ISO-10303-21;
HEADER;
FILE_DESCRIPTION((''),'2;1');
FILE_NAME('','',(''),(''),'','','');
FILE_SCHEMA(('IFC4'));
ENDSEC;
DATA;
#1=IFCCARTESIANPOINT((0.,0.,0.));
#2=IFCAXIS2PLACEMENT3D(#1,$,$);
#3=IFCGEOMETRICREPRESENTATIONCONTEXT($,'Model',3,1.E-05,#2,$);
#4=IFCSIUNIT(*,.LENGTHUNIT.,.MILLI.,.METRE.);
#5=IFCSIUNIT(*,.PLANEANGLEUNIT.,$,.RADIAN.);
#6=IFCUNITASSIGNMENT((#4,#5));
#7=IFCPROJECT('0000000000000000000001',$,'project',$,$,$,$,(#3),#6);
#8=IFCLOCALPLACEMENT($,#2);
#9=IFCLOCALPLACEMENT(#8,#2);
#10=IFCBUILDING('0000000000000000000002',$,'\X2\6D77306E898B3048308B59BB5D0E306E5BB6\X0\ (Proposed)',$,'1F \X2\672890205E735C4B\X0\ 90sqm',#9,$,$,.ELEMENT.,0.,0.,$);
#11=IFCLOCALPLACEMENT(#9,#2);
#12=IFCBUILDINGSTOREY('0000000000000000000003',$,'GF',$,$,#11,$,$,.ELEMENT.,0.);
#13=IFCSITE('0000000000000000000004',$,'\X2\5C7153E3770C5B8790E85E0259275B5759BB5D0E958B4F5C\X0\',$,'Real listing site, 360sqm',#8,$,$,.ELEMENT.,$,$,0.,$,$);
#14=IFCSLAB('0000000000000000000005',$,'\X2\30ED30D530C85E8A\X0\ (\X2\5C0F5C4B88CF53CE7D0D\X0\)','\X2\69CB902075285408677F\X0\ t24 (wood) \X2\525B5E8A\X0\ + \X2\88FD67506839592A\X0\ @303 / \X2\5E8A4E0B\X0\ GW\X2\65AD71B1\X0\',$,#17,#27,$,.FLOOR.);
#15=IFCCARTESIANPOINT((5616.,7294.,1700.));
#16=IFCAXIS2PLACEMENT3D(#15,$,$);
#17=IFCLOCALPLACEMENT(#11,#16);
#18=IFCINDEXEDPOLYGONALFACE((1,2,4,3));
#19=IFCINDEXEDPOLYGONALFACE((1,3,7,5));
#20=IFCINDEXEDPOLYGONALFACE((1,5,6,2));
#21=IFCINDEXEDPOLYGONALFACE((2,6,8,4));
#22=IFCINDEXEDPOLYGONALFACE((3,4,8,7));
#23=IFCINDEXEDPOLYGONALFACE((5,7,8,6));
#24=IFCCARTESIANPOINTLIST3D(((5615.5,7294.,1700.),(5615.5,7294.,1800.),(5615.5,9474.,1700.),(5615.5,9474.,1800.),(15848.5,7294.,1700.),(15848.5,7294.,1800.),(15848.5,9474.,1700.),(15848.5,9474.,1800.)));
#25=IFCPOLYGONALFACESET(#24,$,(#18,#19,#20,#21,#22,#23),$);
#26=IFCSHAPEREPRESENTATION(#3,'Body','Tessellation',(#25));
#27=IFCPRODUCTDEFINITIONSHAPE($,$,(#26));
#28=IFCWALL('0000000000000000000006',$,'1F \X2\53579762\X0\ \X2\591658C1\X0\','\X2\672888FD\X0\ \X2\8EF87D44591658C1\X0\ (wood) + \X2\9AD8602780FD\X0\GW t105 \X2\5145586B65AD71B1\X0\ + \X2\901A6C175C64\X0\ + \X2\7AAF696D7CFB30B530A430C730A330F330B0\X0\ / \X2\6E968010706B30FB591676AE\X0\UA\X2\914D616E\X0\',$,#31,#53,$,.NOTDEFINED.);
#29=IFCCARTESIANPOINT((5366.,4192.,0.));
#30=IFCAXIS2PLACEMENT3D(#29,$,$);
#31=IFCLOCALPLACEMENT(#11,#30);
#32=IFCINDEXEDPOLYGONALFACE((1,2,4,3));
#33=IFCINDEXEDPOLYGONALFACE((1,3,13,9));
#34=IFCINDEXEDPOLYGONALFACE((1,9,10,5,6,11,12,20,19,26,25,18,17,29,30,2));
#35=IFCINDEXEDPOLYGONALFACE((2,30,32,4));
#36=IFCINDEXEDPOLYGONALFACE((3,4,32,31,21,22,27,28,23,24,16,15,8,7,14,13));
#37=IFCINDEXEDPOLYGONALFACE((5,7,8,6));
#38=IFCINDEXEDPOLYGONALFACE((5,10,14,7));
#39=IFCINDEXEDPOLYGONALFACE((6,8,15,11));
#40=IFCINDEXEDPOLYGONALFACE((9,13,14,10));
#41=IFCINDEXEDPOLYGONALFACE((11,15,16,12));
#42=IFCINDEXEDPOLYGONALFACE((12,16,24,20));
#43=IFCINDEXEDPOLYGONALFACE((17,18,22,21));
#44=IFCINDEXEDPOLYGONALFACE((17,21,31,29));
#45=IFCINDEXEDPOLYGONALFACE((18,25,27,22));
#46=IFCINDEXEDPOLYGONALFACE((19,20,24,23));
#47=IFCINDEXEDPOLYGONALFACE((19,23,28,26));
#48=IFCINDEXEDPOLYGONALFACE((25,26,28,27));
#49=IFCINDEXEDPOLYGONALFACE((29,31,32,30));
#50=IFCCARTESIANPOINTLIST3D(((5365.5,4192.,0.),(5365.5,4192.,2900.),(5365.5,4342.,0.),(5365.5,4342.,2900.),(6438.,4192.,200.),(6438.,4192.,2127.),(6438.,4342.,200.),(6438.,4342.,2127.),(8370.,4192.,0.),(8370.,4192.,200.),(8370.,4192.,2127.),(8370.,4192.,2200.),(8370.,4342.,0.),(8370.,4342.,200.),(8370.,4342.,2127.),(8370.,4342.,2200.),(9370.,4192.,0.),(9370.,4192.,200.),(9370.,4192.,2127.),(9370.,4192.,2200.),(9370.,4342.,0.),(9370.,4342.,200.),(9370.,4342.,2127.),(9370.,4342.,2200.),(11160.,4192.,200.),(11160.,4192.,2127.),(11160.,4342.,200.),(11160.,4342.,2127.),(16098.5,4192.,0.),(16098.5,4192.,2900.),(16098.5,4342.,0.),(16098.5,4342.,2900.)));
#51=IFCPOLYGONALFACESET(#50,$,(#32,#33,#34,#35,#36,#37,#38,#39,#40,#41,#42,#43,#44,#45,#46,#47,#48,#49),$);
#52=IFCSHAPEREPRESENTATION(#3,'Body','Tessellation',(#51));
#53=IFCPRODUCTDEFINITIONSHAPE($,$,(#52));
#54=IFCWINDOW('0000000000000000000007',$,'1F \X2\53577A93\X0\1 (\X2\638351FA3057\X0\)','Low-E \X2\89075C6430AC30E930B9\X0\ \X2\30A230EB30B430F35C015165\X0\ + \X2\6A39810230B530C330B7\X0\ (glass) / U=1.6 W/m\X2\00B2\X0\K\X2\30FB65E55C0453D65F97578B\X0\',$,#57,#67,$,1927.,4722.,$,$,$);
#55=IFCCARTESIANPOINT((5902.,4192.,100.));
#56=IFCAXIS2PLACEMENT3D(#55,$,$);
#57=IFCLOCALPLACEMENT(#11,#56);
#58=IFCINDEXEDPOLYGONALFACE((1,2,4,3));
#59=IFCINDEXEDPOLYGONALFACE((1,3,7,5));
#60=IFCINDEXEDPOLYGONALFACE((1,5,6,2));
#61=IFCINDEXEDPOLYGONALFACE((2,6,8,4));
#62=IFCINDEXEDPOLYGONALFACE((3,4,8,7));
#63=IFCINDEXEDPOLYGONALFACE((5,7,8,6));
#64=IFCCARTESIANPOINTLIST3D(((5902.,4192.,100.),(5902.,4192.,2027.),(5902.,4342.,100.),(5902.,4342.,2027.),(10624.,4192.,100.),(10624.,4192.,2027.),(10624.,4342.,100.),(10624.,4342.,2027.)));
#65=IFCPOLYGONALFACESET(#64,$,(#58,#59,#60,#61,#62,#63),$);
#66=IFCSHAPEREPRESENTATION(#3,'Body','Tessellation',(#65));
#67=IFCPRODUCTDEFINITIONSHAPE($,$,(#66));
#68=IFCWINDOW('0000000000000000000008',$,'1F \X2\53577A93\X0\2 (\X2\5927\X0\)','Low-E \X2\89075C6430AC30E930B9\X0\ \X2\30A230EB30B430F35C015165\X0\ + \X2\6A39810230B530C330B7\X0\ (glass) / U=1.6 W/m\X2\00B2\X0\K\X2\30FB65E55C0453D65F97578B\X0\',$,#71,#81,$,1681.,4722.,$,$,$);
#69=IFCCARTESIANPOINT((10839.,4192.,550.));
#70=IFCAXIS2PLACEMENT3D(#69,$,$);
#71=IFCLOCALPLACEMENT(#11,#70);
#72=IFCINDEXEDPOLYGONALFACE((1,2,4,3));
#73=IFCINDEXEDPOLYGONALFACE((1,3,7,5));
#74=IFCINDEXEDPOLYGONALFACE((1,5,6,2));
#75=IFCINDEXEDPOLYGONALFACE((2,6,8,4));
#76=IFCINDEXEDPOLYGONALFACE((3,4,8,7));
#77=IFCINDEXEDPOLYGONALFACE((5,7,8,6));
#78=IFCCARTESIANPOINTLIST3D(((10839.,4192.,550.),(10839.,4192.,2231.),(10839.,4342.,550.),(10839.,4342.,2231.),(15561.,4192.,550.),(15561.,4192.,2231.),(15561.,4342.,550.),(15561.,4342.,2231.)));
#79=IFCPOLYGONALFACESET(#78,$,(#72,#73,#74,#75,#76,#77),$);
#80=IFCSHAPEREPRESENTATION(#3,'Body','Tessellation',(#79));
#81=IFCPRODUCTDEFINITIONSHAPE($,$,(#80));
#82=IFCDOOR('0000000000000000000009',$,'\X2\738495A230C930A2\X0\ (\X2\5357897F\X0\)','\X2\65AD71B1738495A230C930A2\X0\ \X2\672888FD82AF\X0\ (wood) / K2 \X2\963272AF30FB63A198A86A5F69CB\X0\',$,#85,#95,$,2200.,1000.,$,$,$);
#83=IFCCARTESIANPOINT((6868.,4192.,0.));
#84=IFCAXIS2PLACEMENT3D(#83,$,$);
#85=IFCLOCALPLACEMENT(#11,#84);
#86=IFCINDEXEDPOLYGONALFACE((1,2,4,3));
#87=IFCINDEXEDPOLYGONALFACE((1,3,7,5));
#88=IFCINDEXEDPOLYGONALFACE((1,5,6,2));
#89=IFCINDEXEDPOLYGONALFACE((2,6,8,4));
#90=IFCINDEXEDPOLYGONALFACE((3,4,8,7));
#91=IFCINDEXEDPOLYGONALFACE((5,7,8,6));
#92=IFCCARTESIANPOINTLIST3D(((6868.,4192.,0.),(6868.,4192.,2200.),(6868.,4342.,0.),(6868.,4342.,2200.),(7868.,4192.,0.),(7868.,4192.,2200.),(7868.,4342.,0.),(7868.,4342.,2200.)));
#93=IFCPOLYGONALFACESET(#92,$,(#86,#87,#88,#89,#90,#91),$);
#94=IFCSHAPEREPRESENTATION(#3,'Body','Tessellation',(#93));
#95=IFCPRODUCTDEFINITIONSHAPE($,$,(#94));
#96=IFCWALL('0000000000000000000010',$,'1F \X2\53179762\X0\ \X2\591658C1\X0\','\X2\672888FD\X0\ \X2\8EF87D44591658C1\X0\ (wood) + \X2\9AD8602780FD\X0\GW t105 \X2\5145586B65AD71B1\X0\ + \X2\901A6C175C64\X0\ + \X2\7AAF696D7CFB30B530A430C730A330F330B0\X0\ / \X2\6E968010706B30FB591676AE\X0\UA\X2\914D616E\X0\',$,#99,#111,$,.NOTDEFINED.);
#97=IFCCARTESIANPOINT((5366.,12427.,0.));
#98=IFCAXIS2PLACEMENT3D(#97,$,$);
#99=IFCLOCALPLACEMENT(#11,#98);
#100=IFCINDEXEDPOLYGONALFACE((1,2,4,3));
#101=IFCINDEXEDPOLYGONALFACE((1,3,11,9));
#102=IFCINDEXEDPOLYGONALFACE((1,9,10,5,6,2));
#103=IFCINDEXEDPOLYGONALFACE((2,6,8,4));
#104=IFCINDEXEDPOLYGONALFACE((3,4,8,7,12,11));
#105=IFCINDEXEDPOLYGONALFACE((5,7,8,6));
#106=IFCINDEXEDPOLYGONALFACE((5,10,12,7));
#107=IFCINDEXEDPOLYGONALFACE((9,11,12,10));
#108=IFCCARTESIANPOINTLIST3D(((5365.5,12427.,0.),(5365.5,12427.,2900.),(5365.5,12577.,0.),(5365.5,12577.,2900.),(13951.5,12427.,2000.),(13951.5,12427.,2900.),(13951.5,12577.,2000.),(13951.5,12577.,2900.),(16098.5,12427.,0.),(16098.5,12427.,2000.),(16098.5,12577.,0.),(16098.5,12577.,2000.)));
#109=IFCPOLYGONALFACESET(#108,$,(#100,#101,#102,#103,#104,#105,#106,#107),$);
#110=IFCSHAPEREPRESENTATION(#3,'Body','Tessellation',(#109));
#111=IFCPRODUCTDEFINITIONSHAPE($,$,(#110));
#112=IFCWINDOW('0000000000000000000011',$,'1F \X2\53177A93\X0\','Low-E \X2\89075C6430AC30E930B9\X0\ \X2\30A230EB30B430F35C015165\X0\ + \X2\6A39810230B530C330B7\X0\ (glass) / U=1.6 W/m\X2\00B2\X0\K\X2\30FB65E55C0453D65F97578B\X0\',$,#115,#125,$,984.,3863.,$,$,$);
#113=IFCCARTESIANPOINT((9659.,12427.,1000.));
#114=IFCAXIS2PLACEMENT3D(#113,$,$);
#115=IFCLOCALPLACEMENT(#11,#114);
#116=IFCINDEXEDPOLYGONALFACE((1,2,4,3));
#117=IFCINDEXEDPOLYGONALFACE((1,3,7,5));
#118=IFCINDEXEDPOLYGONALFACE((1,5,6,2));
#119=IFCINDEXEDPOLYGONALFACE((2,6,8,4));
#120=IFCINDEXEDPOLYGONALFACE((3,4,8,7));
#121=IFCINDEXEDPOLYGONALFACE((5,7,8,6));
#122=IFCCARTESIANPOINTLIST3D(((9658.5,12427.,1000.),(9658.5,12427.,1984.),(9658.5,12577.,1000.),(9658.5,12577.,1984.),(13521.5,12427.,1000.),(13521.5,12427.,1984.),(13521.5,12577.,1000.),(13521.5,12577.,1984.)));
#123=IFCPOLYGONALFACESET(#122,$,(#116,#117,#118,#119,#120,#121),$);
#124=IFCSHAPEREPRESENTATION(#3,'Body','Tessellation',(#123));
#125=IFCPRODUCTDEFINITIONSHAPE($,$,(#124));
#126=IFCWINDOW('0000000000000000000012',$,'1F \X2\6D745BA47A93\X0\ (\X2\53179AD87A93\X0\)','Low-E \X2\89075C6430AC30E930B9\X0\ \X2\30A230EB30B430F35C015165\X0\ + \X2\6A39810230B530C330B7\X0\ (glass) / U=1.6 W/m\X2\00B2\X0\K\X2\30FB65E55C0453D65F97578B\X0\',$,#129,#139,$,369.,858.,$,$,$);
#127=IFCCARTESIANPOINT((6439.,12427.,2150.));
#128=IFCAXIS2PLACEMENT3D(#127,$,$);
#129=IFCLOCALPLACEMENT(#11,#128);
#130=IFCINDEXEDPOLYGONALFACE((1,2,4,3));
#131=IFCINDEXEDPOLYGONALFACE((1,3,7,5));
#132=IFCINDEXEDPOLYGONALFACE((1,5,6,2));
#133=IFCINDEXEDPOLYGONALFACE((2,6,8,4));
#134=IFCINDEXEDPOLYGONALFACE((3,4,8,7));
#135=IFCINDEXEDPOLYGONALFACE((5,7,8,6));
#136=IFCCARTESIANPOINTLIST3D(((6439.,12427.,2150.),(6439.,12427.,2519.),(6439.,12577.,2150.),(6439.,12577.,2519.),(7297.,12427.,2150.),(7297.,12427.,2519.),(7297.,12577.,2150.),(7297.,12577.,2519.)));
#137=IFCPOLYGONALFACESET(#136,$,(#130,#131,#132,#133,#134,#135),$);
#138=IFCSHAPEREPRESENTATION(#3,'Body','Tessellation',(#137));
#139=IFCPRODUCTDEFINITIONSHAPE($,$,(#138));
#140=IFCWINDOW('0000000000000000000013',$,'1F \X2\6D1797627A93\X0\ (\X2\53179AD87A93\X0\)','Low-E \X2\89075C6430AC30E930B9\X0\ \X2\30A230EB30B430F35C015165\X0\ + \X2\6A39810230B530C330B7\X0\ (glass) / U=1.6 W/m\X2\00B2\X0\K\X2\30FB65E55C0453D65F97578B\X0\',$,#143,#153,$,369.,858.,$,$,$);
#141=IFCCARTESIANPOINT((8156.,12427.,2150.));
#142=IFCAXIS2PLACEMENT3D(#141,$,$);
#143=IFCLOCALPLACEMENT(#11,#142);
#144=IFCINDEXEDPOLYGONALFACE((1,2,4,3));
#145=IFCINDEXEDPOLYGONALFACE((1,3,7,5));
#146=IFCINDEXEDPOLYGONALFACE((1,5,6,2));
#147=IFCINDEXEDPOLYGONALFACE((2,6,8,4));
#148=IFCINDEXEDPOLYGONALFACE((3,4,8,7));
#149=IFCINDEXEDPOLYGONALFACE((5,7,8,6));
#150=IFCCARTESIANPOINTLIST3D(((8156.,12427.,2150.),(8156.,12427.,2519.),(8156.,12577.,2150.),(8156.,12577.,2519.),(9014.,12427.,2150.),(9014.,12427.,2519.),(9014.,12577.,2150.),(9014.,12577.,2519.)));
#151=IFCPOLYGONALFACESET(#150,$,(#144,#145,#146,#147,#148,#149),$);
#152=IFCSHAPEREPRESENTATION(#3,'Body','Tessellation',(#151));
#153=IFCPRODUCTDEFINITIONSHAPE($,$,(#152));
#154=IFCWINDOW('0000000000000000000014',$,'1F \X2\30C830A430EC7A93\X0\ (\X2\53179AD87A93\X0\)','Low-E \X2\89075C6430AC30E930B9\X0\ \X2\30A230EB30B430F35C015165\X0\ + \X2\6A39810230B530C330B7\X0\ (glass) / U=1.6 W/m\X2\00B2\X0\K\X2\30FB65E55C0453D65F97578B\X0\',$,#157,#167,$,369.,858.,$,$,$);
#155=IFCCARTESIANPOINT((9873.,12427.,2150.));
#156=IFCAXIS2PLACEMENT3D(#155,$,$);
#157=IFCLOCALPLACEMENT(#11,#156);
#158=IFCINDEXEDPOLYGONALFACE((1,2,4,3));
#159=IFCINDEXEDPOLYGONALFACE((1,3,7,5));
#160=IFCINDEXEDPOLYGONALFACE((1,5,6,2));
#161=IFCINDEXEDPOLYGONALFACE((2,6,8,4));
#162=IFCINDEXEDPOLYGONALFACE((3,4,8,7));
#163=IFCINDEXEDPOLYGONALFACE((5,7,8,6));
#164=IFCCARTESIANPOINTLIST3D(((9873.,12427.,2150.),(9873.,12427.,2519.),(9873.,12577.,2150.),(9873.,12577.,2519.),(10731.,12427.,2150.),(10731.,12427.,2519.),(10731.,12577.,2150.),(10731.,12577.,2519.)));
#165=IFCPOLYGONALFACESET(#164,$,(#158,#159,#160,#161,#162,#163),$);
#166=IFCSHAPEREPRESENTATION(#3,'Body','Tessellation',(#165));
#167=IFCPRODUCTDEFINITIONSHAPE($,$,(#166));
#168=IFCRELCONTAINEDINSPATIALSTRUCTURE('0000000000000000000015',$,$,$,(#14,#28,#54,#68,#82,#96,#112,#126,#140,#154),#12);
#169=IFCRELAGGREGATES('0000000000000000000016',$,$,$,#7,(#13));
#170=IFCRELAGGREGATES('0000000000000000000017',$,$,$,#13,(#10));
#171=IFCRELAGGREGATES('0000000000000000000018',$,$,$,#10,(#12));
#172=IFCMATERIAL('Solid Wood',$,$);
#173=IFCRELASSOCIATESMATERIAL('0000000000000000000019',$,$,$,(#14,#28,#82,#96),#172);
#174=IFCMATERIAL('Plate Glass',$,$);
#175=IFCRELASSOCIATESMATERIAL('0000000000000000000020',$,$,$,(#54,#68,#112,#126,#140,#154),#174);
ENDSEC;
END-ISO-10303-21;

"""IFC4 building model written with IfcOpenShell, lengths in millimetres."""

from ifc_helpers import new_model, si_unit, frame, frame_2d, origin, place, context, project, spatial, rectangle, extrude, material, element, fill, save


model = new_model("IFC4")

# Units and contexts
model_context = context("Model", 3, precision=1e-05, world=origin())
ifc_project = project(units=[si_unit("LENGTHUNIT", "METRE", prefix="MILLI"), si_unit("PLANEANGLEUNIT", "RADIAN")], contexts=[model_context])

# Site, building, storey
site_placement = place(None, origin())
site = spatial("IfcSite", under=ifc_project, at=site_placement, Name="山口県宇部市大字妻崎開作", ObjectType="Real listing site, 360sqm", CompositionType="ELEMENT", RefElevation=0.0)
building_placement = place(site_placement, origin())
building = spatial("IfcBuilding", under=site, at=building_placement, Name="海の見える妻崎の家 (Proposed)", ObjectType="1F 木造平屋 90sqm", CompositionType="ELEMENT", ElevationOfRefHeight=0.0, ElevationOfTerrain=0.0)
storey_placement = place(building_placement, origin())
storey = spatial("IfcBuildingStorey", under=building, at=storey_placement, Name="GF", CompositionType="ELEMENT", Elevation=0.0)

# Slab
ifc_material_1 = material(Name="Solid Wood")
slab_1_placement = place(storey_placement, frame((5616.0, 7294.0, 1700.0)))
element("IfcSlab", 1, at=slab_1_placement, inside=storey, material=ifc_material_1, Name="ロフト床 (小屋裏収納)", Description="構造用合板 t24 (wood) 剛床 + 製材根太 @303 / 床下 GW断熱", PredefinedType="FLOOR", context=model_context, shape_type="SweptSolid", body=[
    extrude(rectangle(XDim=10233.0, YDim=2180.0, at=frame_2d((5116.0, 1090.0))), frame((5616.0, 7294.0, 1700.0)), (0.0, 0.0, 1.0), 100.0),
])

# Wall, openings, windows, door
wall_1_placement = place(storey_placement, frame((5366.0, 4192.0, 0.0)))
wall_1 = element("IfcWall", 2, at=wall_1_placement, inside=storey, material=ifc_material_1, Name="1F 南面 外壁", Description="木製 軸組外壁 (wood) + 高性能GW t105 充填断熱 + 通気層 + 窯業系サイディング / 準耐火・外皮UA配慮", PredefinedType="NOTDEFINED", context=model_context, shape_type="SweptSolid", body=[
    extrude(rectangle(XDim=10733.0, YDim=150.0, at=frame_2d((5366.0, 75.0))), frame((5366.0, 4192.0, 0.0)), (0.0, 0.0, 1.0), 2900.0),
])
opening_1_placement = place(storey_placement, frame((5902.0, 4192.0, 100.0)))
opening_1 = element("IfcOpeningElement", 3, at=opening_1_placement, cuts=wall_1, PredefinedType="NOTDEFINED", context=model_context, shape_type="SweptSolid", body=[
    extrude(rectangle(XDim=4722.0, YDim=150.0, at=frame_2d((2361.0, 75.0))), frame((5902.0, 4192.0, 100.0)), (0.0, 0.0, 1.0), 1927.0),
])
opening_2_placement = place(storey_placement, frame((10839.0, 4192.0, 550.0)))
opening_2 = element("IfcOpeningElement", 4, at=opening_2_placement, cuts=wall_1, PredefinedType="NOTDEFINED", context=model_context, shape_type="SweptSolid", body=[
    extrude(rectangle(XDim=4722.0, YDim=150.0, at=frame_2d((2361.0, 75.0))), frame((10839.0, 4192.0, 550.0)), (0.0, 0.0, 1.0), 1681.0),
])
opening_3_placement = place(storey_placement, frame((6868.0, 4192.0, 0.0)))
opening_3 = element("IfcOpeningElement", 5, at=opening_3_placement, cuts=wall_1, PredefinedType="NOTDEFINED", context=model_context, shape_type="SweptSolid", body=[
    extrude(rectangle(XDim=1000.0, YDim=150.0, at=frame_2d((500.0, 75.0))), frame((6868.0, 4192.0, 0.0)), (0.0, 0.0, 1.0), 2200.0),
])
ifc_material_2 = material(Name="Plate Glass")
window_1_placement = place(storey_placement, frame((5902.0, 4192.0, 100.0)))
window_1 = element("IfcWindow", 6, at=window_1_placement, inside=storey, material=ifc_material_2, Name="1F 南窓1 (掃出し)", Description="Low-E 複層ガラス アルゴン封入 + 樹脂サッシ (glass) / U=1.6 W/m²K・日射取得型", OverallHeight=1927.0, OverallWidth=4722.0, context=model_context, shape_type="SweptSolid", body=[
    extrude(rectangle(XDim=4722.0, YDim=150.0, at=frame_2d((2361.0, 75.0))), frame((5902.0, 4192.0, 100.0)), (0.0, 0.0, 1.0), 1927.0),
])
fill(opening_1, window_1)
window_2_placement = place(storey_placement, frame((10839.0, 4192.0, 550.0)))
window_2 = element("IfcWindow", 7, at=window_2_placement, inside=storey, material=ifc_material_2, Name="1F 南窓2 (大)", Description="Low-E 複層ガラス アルゴン封入 + 樹脂サッシ (glass) / U=1.6 W/m²K・日射取得型", OverallHeight=1681.0, OverallWidth=4722.0, context=model_context, shape_type="SweptSolid", body=[
    extrude(rectangle(XDim=4722.0, YDim=150.0, at=frame_2d((2361.0, 75.0))), frame((10839.0, 4192.0, 550.0)), (0.0, 0.0, 1.0), 1681.0),
])
fill(opening_2, window_2)
door_1_placement = place(storey_placement, frame((6868.0, 4192.0, 0.0)))
door_1 = element("IfcDoor", 8, at=door_1_placement, inside=storey, material=ifc_material_1, Name="玄関ドア (南西)", Description="断熱玄関ドア 木製芯 (wood) / K2 防犯・採風機構", OverallHeight=2200.0, OverallWidth=1000.0, context=model_context, shape_type="SweptSolid", body=[
    extrude(rectangle(XDim=1000.0, YDim=150.0, at=frame_2d((500.0, 75.0))), frame((6868.0, 4192.0, 0.0)), (0.0, 0.0, 1.0), 2200.0),
])
fill(opening_3, door_1)

# Wall, openings, windows
wall_2_placement = place(storey_placement, frame((5366.0, 12427.0, 0.0)))
wall_2 = element("IfcWall", 9, at=wall_2_placement, inside=storey, material=ifc_material_1, Name="1F 北面 外壁", Description="木製 軸組外壁 (wood) + 高性能GW t105 充填断熱 + 通気層 + 窯業系サイディング / 準耐火・外皮UA配慮", PredefinedType="NOTDEFINED", context=model_context, shape_type="SweptSolid", body=[
    extrude(rectangle(XDim=10733.0, YDim=150.0, at=frame_2d((5366.0, 75.0))), frame((5366.0, 12427.0, 0.0)), (0.0, 0.0, 1.0), 2900.0),
])
opening_4_placement = place(storey_placement, frame((9659.0, 12427.0, 1000.0)))
opening_4 = element("IfcOpeningElement", 10, at=opening_4_placement, cuts=wall_2, PredefinedType="NOTDEFINED", context=model_context, shape_type="SweptSolid", body=[
    extrude(rectangle(XDim=3863.0, YDim=150.0, at=frame_2d((1931.0, 75.0))), frame((9659.0, 12427.0, 1000.0)), (0.0, 0.0, 1.0), 984.0),
])
opening_5_placement = place(storey_placement, frame((6439.0, 12427.0, 2150.0)))
opening_5 = element("IfcOpeningElement", 11, at=opening_5_placement, cuts=wall_2, PredefinedType="NOTDEFINED", context=model_context, shape_type="SweptSolid", body=[
    extrude(rectangle(XDim=858.0, YDim=150.0, at=frame_2d((429.0, 75.0))), frame((6439.0, 12427.0, 2150.0)), (0.0, 0.0, 1.0), 369.0),
])
opening_6_placement = place(storey_placement, frame((8156.0, 12427.0, 2150.0)))
opening_6 = element("IfcOpeningElement", 12, at=opening_6_placement, cuts=wall_2, PredefinedType="NOTDEFINED", context=model_context, shape_type="SweptSolid", body=[
    extrude(rectangle(XDim=858.0, YDim=150.0, at=frame_2d((429.0, 75.0))), frame((8156.0, 12427.0, 2150.0)), (0.0, 0.0, 1.0), 369.0),
])
opening_7_placement = place(storey_placement, frame((9873.0, 12427.0, 2150.0)))
opening_7 = element("IfcOpeningElement", 13, at=opening_7_placement, cuts=wall_2, PredefinedType="NOTDEFINED", context=model_context, shape_type="SweptSolid", body=[
    extrude(rectangle(XDim=858.0, YDim=150.0, at=frame_2d((429.0, 75.0))), frame((9873.0, 12427.0, 2150.0)), (0.0, 0.0, 1.0), 369.0),
])
window_3_placement = place(storey_placement, frame((9659.0, 12427.0, 1000.0)))
window_3 = element("IfcWindow", 14, at=window_3_placement, inside=storey, material=ifc_material_2, Name="1F 北窓", Description="Low-E 複層ガラス アルゴン封入 + 樹脂サッシ (glass) / U=1.6 W/m²K・日射取得型", OverallHeight=984.0, OverallWidth=3863.0, context=model_context, shape_type="SweptSolid", body=[
    extrude(rectangle(XDim=3863.0, YDim=150.0, at=frame_2d((1931.0, 75.0))), frame((9659.0, 12427.0, 1000.0)), (0.0, 0.0, 1.0), 984.0),
])
fill(opening_4, window_3)
window_4_placement = place(storey_placement, frame((6439.0, 12427.0, 2150.0)))
window_4 = element("IfcWindow", 15, at=window_4_placement, inside=storey, material=ifc_material_2, Name="1F 浴室窓 (北高窓)", Description="Low-E 複層ガラス アルゴン封入 + 樹脂サッシ (glass) / U=1.6 W/m²K・日射取得型", OverallHeight=369.0, OverallWidth=858.0, context=model_context, shape_type="SweptSolid", body=[
    extrude(rectangle(XDim=858.0, YDim=150.0, at=frame_2d((429.0, 75.0))), frame((6439.0, 12427.0, 2150.0)), (0.0, 0.0, 1.0), 369.0),
])
fill(opening_5, window_4)
window_5_placement = place(storey_placement, frame((8156.0, 12427.0, 2150.0)))
window_5 = element("IfcWindow", 16, at=window_5_placement, inside=storey, material=ifc_material_2, Name="1F 洗面窓 (北高窓)", Description="Low-E 複層ガラス アルゴン封入 + 樹脂サッシ (glass) / U=1.6 W/m²K・日射取得型", OverallHeight=369.0, OverallWidth=858.0, context=model_context, shape_type="SweptSolid", body=[
    extrude(rectangle(XDim=858.0, YDim=150.0, at=frame_2d((429.0, 75.0))), frame((8156.0, 12427.0, 2150.0)), (0.0, 0.0, 1.0), 369.0),
])
fill(opening_6, window_5)
window_6_placement = place(storey_placement, frame((9873.0, 12427.0, 2150.0)))
window_6 = element("IfcWindow", 17, at=window_6_placement, inside=storey, material=ifc_material_2, Name="1F トイレ窓 (北高窓)", Description="Low-E 複層ガラス アルゴン封入 + 樹脂サッシ (glass) / U=1.6 W/m²K・日射取得型", OverallHeight=369.0, OverallWidth=858.0, context=model_context, shape_type="SweptSolid", body=[
    extrude(rectangle(XDim=858.0, YDim=150.0, at=frame_2d((429.0, 75.0))), frame((9873.0, 12427.0, 2150.0)), (0.0, 0.0, 1.0), 369.0),
])
fill(opening_7, window_6)

save(model, "model.ifc")
